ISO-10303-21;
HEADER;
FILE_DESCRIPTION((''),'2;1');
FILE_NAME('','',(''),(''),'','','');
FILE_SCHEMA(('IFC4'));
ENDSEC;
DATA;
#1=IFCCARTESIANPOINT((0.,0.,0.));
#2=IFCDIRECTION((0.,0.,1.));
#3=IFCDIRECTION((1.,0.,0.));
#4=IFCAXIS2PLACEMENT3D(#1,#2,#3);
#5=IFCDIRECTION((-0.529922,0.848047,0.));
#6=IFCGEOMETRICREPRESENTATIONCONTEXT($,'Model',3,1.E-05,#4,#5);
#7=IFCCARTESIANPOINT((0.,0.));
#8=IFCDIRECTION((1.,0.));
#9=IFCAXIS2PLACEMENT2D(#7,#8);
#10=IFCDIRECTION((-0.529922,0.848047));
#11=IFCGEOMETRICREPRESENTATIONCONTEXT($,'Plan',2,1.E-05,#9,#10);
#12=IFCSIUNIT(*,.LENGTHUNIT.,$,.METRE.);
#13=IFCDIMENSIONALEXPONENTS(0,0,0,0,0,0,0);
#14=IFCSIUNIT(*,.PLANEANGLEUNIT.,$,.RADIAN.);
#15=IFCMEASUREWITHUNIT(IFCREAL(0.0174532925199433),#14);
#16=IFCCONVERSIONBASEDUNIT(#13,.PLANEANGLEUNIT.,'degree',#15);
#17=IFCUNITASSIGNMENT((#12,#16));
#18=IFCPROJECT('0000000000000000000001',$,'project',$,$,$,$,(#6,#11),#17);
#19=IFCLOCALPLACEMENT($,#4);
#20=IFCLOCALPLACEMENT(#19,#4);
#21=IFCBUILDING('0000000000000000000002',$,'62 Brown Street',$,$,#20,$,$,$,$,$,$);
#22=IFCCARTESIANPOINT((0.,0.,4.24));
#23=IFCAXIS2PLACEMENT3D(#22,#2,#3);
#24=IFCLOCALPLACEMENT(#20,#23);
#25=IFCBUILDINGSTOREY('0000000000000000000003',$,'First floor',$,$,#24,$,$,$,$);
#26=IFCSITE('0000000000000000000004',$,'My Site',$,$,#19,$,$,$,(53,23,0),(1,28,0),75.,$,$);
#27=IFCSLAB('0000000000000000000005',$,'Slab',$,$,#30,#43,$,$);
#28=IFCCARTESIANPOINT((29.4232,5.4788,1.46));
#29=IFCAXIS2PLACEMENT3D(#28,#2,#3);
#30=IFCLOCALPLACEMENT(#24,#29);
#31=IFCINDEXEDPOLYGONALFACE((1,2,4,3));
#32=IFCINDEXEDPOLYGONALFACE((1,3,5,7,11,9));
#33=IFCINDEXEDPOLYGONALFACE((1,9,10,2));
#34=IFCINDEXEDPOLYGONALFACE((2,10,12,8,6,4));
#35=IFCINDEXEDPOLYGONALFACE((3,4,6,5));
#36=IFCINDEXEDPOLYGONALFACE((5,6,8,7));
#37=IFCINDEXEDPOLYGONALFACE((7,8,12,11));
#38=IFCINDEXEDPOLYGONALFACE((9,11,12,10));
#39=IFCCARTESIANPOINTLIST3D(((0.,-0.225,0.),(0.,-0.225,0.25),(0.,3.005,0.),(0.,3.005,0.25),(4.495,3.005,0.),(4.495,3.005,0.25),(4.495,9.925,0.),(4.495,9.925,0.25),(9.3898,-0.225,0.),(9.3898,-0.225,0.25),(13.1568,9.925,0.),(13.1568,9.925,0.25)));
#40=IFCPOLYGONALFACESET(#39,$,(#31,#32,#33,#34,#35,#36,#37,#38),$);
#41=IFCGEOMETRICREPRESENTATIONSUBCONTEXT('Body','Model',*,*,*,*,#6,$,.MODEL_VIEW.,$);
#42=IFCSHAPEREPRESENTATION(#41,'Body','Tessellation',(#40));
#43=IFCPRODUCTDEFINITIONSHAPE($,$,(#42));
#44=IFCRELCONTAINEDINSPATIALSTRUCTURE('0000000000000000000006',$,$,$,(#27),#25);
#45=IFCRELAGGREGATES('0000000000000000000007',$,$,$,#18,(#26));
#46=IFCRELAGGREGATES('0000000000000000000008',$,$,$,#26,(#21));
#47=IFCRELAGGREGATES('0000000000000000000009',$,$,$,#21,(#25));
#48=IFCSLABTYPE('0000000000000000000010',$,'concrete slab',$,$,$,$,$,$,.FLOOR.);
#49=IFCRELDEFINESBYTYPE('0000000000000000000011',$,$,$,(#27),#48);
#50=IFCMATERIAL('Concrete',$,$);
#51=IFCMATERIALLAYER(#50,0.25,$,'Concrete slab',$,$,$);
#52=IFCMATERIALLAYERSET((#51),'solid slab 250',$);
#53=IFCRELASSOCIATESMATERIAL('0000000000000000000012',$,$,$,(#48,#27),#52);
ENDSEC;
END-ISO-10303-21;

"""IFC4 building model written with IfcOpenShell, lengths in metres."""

from ifc_helpers import new_model, entity, si_unit, converted_unit, direction, frame, origin_with_axes, origin_2d_with_axis, place, context, subcontext, project, spatial, line, indexed_curve, outline, extrude, material, layer, layer_set, layer_usage, type_object, element, save


model = new_model("IFC4")

# Units and contexts
model_context = context("Model", 3, precision=1e-05, world=origin_with_axes(), true_north=direction((-0.529922, 0.848047, 0.0)))
plan_context = context("Plan", 2, precision=1e-05, world=origin_2d_with_axis(), true_north=direction((-0.529922, 0.848047)))
body_context_1 = subcontext(model_context, "Body", "Model", "MODEL_VIEW")
ifc_project = project(units=[si_unit("LENGTHUNIT", "METRE"), converted_unit("PLANEANGLEUNIT", "degree", entity("IfcReal", 0.0174532925199433), si_unit("PLANEANGLEUNIT", "RADIAN"), dimensions=[0, 0, 0, 0, 0, 0, 0])], contexts=[model_context, plan_context])

# Site, building, storey
site_placement = place(None, origin_with_axes())
site = spatial("IfcSite", under=ifc_project, at=site_placement, Name="My Site", RefLatitude=(53, 23, 0), RefLongitude=(1, 28, 0), RefElevation=75.0)
building_placement = place(site_placement, origin_with_axes())
building = spatial("IfcBuilding", under=site, at=building_placement, Name="62 Brown Street")
storey_placement = place(building_placement, frame((0.0, 0.0, 4.24), z_axis=(0.0, 0.0, 1.0), x_axis=(1.0, 0.0, 0.0)))
storey = spatial("IfcBuildingStorey", under=building, at=storey_placement, Name="First floor")

# Shared definitions
ifc_material_1 = material(Name="Concrete")

# Slab
ifc_layer_1 = layer(ifc_material_1, 0.25, Name="Concrete slab")
ifc_layer_set_1 = layer_set([ifc_layer_1], Name="solid slab 250")
slab_type = type_object("IfcSlabType", Name="concrete slab", PredefinedType="FLOOR", material=ifc_layer_set_1)
ifc_layer_usage_1 = layer_usage(ifc_layer_set_1, "AXIS3", "POSITIVE", 0.0)
slab_1_placement = place(storey_placement, frame((29.4232, 5.4788, 1.46), z_axis=(0.0, 0.0, 1.0), x_axis=(1.0, 0.0, 0.0)))
element("IfcSlab", 1, at=slab_1_placement, inside=storey, type_object=slab_type, material=ifc_layer_usage_1, Name="Slab", context=body_context_1, shape_type="SweptSolid", body=[
    extrude(outline(indexed_curve([(0.0, 3.005), (0.0, -0.225), (9.3898, -0.225), (13.1568, 9.925), (4.495, 9.925), (4.495, 3.005)], segments=[line(4, 3), line(3, 2), line(2, 1), line(1, 6), line(6, 5), line(5, 4)], self_intersect=False)), None, (0.0, 0.0, 1.0), 0.25),
])

save(model, "model.ifc")
